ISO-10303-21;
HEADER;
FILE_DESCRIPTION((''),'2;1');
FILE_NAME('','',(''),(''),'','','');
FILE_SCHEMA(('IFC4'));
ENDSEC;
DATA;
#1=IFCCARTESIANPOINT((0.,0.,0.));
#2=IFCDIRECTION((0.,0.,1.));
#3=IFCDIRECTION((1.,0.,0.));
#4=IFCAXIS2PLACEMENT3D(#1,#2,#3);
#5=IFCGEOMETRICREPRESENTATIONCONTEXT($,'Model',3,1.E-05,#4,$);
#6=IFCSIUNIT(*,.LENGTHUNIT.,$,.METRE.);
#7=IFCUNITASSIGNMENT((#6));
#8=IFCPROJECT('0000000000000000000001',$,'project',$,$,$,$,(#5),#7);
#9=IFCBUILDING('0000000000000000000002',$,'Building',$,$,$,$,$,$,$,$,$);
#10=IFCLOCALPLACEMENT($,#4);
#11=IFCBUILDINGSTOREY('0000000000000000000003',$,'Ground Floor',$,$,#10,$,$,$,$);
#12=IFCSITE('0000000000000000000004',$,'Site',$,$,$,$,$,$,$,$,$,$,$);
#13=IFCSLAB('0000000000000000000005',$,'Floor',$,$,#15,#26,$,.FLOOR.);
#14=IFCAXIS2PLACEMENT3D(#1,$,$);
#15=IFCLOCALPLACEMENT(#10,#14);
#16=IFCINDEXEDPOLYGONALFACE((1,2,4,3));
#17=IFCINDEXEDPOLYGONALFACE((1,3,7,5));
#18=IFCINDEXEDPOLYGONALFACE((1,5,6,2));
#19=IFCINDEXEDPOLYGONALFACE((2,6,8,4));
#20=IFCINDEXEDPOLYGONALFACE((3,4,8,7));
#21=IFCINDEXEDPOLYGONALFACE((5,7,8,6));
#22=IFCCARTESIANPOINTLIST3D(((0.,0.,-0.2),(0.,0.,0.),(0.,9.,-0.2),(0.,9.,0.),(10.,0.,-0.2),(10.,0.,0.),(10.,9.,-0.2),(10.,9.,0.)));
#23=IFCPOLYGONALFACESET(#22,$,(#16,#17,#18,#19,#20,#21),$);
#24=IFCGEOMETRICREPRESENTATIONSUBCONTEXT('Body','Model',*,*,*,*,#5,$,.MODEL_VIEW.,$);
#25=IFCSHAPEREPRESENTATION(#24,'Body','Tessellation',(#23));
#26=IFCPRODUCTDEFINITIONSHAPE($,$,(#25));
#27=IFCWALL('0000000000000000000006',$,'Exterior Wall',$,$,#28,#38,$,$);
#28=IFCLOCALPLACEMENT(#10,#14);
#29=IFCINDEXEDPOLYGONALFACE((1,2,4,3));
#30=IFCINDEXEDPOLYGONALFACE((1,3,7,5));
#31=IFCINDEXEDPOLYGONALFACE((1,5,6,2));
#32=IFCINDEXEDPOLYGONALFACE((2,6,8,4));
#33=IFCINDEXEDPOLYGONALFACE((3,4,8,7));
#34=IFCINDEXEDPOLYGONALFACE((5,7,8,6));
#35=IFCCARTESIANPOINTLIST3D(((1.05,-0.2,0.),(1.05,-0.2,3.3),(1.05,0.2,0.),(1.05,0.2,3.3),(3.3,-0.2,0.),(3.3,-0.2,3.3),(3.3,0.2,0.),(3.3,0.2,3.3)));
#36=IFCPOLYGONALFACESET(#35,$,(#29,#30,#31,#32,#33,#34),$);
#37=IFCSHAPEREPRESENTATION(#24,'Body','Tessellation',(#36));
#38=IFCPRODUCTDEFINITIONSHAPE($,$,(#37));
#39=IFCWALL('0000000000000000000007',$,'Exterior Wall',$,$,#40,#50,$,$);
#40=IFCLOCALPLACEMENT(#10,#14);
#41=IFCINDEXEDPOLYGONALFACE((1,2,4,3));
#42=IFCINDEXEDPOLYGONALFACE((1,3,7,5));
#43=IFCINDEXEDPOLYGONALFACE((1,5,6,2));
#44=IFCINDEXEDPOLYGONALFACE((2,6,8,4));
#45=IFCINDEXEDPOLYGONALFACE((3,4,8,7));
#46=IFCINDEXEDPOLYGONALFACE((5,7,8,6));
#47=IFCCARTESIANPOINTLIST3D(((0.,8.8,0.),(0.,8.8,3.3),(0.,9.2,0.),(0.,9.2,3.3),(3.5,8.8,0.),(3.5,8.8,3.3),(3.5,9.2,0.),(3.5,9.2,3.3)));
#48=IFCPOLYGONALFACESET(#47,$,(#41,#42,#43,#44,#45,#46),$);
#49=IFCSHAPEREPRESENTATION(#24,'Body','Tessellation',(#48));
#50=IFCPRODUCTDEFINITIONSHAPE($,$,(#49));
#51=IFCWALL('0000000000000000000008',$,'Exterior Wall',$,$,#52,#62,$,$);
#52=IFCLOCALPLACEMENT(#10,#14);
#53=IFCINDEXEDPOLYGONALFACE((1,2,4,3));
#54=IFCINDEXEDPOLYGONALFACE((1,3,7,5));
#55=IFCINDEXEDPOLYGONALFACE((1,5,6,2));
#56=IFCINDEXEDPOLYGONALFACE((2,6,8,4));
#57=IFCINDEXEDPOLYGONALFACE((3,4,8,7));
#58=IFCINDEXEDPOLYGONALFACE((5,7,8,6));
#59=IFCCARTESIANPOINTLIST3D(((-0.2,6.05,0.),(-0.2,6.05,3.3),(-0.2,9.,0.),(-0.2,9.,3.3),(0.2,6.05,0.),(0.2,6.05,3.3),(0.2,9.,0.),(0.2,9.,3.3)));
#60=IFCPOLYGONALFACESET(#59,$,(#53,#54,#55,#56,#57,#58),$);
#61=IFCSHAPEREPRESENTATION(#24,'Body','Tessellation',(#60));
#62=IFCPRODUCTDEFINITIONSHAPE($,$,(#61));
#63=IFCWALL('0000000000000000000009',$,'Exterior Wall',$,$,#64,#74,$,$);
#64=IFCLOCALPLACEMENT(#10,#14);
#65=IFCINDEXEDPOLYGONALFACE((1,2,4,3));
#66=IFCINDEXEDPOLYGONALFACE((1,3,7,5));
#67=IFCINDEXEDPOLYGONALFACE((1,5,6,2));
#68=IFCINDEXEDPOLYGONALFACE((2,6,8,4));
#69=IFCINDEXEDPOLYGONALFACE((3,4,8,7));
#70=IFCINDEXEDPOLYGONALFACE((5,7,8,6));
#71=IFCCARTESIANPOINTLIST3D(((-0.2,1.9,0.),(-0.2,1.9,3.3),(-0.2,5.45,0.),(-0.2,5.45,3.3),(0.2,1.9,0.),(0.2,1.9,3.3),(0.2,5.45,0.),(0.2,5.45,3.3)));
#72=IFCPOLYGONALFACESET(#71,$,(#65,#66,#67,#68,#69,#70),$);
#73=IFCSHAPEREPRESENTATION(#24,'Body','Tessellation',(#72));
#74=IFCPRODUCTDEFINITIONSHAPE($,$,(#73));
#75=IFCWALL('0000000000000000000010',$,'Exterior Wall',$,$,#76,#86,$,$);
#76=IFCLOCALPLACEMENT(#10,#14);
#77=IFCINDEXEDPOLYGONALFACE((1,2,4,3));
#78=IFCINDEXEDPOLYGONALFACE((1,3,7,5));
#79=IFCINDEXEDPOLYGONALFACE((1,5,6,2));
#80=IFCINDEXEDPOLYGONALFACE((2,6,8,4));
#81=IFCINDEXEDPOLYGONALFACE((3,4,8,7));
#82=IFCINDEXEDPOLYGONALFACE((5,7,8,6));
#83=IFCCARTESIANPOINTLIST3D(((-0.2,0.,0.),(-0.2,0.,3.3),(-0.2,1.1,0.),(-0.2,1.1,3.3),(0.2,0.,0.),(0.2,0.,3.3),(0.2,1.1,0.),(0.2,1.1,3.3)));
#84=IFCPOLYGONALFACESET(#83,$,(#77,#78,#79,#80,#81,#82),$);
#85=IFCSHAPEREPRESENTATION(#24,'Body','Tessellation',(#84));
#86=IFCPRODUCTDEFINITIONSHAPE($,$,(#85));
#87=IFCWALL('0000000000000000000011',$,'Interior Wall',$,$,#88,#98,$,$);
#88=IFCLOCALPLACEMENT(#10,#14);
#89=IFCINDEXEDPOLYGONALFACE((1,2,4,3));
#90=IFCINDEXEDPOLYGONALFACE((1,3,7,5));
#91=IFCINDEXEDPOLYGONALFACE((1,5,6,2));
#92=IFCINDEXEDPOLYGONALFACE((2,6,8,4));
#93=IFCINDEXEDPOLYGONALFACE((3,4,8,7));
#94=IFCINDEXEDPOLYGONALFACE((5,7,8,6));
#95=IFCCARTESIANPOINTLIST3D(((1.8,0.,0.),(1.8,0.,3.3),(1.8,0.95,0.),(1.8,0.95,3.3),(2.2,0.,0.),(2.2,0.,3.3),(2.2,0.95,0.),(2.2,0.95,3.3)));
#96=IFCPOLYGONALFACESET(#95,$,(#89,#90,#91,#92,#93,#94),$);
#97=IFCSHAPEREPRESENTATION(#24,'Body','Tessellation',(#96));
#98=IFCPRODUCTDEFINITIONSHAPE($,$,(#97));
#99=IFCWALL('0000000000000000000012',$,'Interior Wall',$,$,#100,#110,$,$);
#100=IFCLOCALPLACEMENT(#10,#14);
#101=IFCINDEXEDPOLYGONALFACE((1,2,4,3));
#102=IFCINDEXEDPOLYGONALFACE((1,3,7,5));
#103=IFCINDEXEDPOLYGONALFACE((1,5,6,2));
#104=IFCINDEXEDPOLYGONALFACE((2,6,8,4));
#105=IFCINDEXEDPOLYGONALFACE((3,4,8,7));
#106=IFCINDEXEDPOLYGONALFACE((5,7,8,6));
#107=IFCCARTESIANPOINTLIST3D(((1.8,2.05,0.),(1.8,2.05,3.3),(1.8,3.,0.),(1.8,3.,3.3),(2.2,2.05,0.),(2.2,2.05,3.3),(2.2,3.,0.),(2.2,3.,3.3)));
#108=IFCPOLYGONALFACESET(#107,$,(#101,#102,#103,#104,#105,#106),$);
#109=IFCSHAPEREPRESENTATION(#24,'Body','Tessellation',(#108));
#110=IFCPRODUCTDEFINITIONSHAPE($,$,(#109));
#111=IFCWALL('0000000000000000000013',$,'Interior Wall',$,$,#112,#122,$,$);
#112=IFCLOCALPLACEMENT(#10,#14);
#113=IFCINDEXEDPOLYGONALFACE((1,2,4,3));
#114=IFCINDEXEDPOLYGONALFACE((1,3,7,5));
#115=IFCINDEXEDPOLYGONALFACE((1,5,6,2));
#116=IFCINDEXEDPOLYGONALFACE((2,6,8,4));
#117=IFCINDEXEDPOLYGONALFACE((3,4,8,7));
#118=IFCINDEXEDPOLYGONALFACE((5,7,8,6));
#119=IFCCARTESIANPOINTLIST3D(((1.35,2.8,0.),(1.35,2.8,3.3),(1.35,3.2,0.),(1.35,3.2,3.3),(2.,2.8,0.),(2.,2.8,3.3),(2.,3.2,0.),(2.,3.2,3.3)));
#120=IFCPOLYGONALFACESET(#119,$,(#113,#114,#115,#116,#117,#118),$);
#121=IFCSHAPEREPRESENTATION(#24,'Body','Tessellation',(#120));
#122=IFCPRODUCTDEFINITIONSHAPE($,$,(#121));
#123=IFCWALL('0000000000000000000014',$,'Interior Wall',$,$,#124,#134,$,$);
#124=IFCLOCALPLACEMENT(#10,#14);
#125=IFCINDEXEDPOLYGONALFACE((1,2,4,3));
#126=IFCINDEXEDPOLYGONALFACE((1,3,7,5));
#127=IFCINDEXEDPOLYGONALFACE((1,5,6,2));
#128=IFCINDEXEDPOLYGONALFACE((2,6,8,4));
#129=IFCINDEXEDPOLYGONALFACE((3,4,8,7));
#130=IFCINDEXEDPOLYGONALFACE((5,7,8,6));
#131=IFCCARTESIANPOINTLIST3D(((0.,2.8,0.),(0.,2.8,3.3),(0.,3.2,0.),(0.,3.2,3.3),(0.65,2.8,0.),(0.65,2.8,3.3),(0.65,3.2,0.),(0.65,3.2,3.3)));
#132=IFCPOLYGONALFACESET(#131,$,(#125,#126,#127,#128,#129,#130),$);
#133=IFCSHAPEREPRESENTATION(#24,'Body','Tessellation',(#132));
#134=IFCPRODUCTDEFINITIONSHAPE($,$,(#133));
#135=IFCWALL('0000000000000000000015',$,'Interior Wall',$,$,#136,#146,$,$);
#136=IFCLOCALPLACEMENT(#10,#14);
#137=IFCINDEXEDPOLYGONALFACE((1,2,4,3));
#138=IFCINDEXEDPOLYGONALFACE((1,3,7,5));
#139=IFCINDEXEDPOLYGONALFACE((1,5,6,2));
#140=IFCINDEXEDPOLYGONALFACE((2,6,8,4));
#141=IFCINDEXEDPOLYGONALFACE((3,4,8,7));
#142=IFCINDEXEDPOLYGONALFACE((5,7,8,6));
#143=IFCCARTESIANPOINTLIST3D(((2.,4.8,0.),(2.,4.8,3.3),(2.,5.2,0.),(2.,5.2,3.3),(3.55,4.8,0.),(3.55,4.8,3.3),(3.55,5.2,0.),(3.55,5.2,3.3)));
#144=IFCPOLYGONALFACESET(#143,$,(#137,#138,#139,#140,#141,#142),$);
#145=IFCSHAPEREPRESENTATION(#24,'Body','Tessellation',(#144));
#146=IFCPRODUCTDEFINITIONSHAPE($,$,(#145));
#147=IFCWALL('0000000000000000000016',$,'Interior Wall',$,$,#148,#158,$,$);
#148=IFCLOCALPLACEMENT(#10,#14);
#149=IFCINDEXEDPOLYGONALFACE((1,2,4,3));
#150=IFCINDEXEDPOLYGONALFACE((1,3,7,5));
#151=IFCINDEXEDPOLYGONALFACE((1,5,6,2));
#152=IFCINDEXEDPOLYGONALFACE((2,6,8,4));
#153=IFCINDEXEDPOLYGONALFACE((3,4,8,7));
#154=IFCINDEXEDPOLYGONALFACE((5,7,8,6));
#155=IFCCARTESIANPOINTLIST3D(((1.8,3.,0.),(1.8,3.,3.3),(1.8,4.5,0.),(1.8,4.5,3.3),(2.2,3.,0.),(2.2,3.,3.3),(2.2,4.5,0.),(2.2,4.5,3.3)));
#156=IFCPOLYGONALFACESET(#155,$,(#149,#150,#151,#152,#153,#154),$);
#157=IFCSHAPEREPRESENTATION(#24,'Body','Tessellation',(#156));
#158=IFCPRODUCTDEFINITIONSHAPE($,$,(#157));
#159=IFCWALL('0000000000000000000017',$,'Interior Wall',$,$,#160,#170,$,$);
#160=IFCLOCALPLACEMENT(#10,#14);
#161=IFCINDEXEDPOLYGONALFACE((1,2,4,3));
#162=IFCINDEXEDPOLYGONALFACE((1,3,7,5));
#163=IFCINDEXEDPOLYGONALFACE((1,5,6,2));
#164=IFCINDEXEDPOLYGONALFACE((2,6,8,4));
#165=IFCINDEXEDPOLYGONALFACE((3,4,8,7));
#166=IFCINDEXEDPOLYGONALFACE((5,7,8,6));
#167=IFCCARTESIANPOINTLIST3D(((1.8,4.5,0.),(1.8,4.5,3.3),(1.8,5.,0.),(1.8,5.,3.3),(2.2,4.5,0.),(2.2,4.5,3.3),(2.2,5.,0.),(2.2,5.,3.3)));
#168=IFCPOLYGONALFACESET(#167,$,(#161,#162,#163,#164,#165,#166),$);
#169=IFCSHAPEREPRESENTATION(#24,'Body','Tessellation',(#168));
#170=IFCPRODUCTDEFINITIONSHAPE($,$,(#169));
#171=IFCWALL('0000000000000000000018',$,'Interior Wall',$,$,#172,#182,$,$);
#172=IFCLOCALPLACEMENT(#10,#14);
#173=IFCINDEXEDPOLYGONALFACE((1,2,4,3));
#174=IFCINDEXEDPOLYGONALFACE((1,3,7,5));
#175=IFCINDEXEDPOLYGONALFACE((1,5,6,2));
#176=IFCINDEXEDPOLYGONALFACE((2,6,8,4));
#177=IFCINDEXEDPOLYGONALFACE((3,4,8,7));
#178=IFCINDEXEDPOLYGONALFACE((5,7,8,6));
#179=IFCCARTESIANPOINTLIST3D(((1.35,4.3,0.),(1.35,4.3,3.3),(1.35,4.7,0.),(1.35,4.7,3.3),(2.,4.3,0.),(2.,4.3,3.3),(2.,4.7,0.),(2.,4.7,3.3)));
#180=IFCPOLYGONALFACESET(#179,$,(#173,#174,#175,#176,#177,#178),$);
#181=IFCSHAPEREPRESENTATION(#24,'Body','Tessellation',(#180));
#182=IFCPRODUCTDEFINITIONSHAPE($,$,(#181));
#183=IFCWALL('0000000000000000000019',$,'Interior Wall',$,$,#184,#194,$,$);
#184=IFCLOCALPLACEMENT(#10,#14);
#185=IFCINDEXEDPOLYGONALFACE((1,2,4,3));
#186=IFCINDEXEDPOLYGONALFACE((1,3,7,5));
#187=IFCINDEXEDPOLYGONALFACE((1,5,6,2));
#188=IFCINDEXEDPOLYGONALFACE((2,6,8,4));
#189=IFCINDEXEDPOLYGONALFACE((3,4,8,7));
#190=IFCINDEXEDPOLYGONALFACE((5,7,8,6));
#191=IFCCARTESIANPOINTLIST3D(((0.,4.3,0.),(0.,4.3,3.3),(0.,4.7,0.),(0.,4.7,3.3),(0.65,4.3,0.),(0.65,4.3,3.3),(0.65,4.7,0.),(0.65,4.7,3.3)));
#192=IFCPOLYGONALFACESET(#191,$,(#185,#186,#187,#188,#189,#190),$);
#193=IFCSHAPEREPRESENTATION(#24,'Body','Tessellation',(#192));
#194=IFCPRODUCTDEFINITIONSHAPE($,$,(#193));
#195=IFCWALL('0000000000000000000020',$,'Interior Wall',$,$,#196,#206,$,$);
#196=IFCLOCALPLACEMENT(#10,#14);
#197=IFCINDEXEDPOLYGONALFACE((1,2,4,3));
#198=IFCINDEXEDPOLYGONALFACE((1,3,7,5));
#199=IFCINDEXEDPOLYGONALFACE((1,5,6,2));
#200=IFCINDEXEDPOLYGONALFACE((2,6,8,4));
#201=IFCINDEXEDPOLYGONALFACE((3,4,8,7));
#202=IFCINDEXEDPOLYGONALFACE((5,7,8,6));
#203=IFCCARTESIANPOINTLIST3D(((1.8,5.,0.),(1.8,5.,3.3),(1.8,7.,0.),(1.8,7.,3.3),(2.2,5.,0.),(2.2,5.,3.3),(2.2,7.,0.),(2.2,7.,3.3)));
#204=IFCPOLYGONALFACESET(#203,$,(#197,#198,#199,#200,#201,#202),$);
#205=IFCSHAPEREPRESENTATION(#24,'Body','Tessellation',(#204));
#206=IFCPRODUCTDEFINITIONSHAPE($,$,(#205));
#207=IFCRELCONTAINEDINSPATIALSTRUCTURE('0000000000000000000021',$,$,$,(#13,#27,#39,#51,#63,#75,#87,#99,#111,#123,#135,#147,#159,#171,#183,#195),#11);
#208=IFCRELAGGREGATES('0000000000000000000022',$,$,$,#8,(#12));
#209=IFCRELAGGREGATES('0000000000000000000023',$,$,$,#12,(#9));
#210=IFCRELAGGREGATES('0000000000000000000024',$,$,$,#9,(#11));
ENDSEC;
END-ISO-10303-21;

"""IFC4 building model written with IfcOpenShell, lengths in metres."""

from ifc_helpers import new_model, si_unit, frame, origin_with_axes, place, context, subcontext, project, spatial, indexed_curve, outline, extrude, element, save


model = new_model("IFC4")

# Units and contexts
model_context = context("Model", 3, precision=1e-05, world=origin_with_axes())
body_context = subcontext(model_context, "Body", "Model", "MODEL_VIEW")
ifc_project = project(units=[si_unit("LENGTHUNIT", "METRE")], contexts=[model_context])

# Site, building, storey
site = spatial("IfcSite", under=ifc_project, Name="Site")
building = spatial("IfcBuilding", under=site, Name="Building")
storey_placement = place(None, origin_with_axes())
storey = spatial("IfcBuildingStorey", under=building, at=storey_placement, Name="Ground Floor")

# Slab
slab_placement = place(storey_placement, frame((0.0, 0.0, -0.2), z_axis=(0.0, 0.0, 1.0), x_axis=(1.0, 0.0, 0.0)))
element("IfcSlab", 1, at=slab_placement, inside=storey, Name="Floor", PredefinedType="FLOOR", context=body_context, shape_type="SweptSolid", body=[
    extrude(outline(indexed_curve([(0.0, 0.0), (10.0, 0.0), (10.0, 9.0), (0.0, 9.0)])), None, (0.0, 0.0, 1.0), 0.2),
])

# Walls
wall_1_placement = place(storey_placement, frame((1.05, 0.0, 0.0), z_axis=(0.0, 0.0, 1.0), x_axis=(1.0, 0.0, 0.0)))
element("IfcWall", 2, at=wall_1_placement, inside=storey, Name="Exterior Wall", context=body_context, shape_type="SweptSolid", body=[
    extrude(outline(indexed_curve([(0.0, 0.0), (0.0, 0.4), (2.25, 0.4), (2.25, 0.0), (0.0, 0.0)], self_intersect=False)), frame((0.0, -0.2, 0.0), z_axis=(0.0, 0.0, 1.0), x_axis=(1.0, 0.0, 0.0)), (0.0, 0.0, 1.0), 3.3),
])
wall_2_placement = place(storey_placement, frame((3.5, 9.0, 0.0), z_axis=(0.0, 0.0, 1.0), x_axis=(-1.0, 0.0, 0.0)))
element("IfcWall", 3, at=wall_2_placement, inside=storey, Name="Exterior Wall", context=body_context, shape_type="SweptSolid", body=[
    extrude(outline(indexed_curve([(0.0, 0.0), (0.0, 0.4), (3.5, 0.4), (3.5, 0.0), (0.0, 0.0)], self_intersect=False)), frame((0.0, -0.2, 0.0), z_axis=(0.0, 0.0, 1.0), x_axis=(1.0, 0.0, 0.0)), (0.0, 0.0, 1.0), 3.3),
])
wall_3_placement = place(storey_placement, frame((0.0, 9.0, 0.0), z_axis=(0.0, 0.0, 1.0), x_axis=(0.0, -1.0, 0.0)))
element("IfcWall", 4, at=wall_3_placement, inside=storey, Name="Exterior Wall", context=body_context, shape_type="SweptSolid", body=[
    extrude(outline(indexed_curve([(0.0, 0.0), (0.0, 0.4), (2.95, 0.4), (2.95, 0.0), (0.0, 0.0)], self_intersect=False)), frame((0.0, -0.2, 0.0), z_axis=(0.0, 0.0, 1.0), x_axis=(1.0, 0.0, 0.0)), (0.0, 0.0, 1.0), 3.3),
])
wall_4_placement = place(storey_placement, frame((0.0, 5.45, 0.0), z_axis=(0.0, 0.0, 1.0), x_axis=(0.0, -1.0, 0.0)))
element("IfcWall", 5, at=wall_4_placement, inside=storey, Name="Exterior Wall", context=body_context, shape_type="SweptSolid", body=[
    extrude(outline(indexed_curve([(0.0, 0.0), (0.0, 0.4), (3.55, 0.4), (3.55, 0.0), (0.0, 0.0)], self_intersect=False)), frame((0.0, -0.2, 0.0), z_axis=(0.0, 0.0, 1.0), x_axis=(1.0, 0.0, 0.0)), (0.0, 0.0, 1.0), 3.3),
])
wall_5_placement = place(storey_placement, frame((0.0, 1.1, 0.0), z_axis=(0.0, 0.0, 1.0), x_axis=(0.0, -1.0, 0.0)))
element("IfcWall", 6, at=wall_5_placement, inside=storey, Name="Exterior Wall", context=body_context, shape_type="SweptSolid", body=[
    extrude(outline(indexed_curve([(0.0, 0.0), (0.0, 0.4), (1.1, 0.4), (1.1, 0.0), (0.0, 0.0)], self_intersect=False)), frame((0.0, -0.2, 0.0), z_axis=(0.0, 0.0, 1.0), x_axis=(1.0, 0.0, 0.0)), (0.0, 0.0, 1.0), 3.3),
])
wall_6_placement = place(storey_placement, frame((2.0, 0.0, 0.0), z_axis=(0.0, 0.0, 1.0), x_axis=(0.0, 1.0, 0.0)))
element("IfcWall", 7, at=wall_6_placement, inside=storey, Name="Interior Wall", context=body_context, shape_type="SweptSolid", body=[
    extrude(outline(indexed_curve([(0.0, 0.0), (0.0, 0.4), (0.95, 0.4), (0.95, 0.0), (0.0, 0.0)], self_intersect=False)), frame((0.0, -0.2, 0.0), z_axis=(0.0, 0.0, 1.0), x_axis=(1.0, 0.0, 0.0)), (0.0, 0.0, 1.0), 3.3),
])
wall_7_placement = place(storey_placement, frame((2.0, 2.05, 0.0), z_axis=(0.0, 0.0, 1.0), x_axis=(0.0, 1.0, 0.0)))
element("IfcWall", 8, at=wall_7_placement, inside=storey, Name="Interior Wall", context=body_context, shape_type="SweptSolid", body=[
    extrude(outline(indexed_curve([(0.0, 0.0), (0.0, 0.4), (0.95, 0.4), (0.95, 0.0), (0.0, 0.0)], self_intersect=False)), frame((0.0, -0.2, 0.0), z_axis=(0.0, 0.0, 1.0), x_axis=(1.0, 0.0, 0.0)), (0.0, 0.0, 1.0), 3.3),
])
for number, where, z_axis, x_axis, name in (
    (9, (2.0, 3.0, 0.0), (0.0, 0.0, 1.0), (-1.0, 0.0, 0.0), "Interior Wall"),
    (10, (0.65, 3.0, 0.0), (0.0, 0.0, 1.0), (-1.0, 0.0, 0.0), "Interior Wall"),
):
    element("IfcWall", number, at=place(storey_placement, frame(where, z_axis=z_axis, x_axis=x_axis)), inside=storey, Name=name, context=body_context, shape_type="SweptSolid", body=[
        extrude(outline(indexed_curve([(0.0, 0.0), (0.0, 0.4), (0.65, 0.4), (0.65, 0.0), (0.0, 0.0)], self_intersect=False)), frame((0.0, -0.2, 0.0), z_axis=(0.0, 0.0, 1.0), x_axis=(1.0, 0.0, 0.0)), (0.0, 0.0, 1.0), 3.3),
    ])
wall_8_placement = place(storey_placement, frame((3.55, 5.0, 0.0), z_axis=(0.0, 0.0, 1.0), x_axis=(-1.0, 0.0, 0.0)))
element("IfcWall", 11, at=wall_8_placement, inside=storey, Name="Interior Wall", context=body_context, shape_type="SweptSolid", body=[
    extrude(outline(indexed_curve([(0.0, 0.0), (0.0, 0.4), (1.55, 0.4), (1.55, 0.0), (0.0, 0.0)], self_intersect=False)), frame((0.0, -0.2, 0.0), z_axis=(0.0, 0.0, 1.0), x_axis=(1.0, 0.0, 0.0)), (0.0, 0.0, 1.0), 3.3),
])
wall_9_placement = place(storey_placement, frame((2.0, 4.5, 0.0), z_axis=(0.0, 0.0, 1.0), x_axis=(0.0, -1.0, 0.0)))
element("IfcWall", 12, at=wall_9_placement, inside=storey, Name="Interior Wall", context=body_context, shape_type="SweptSolid", body=[
    extrude(outline(indexed_curve([(0.0, 0.0), (0.0, 0.4), (1.5, 0.4), (1.5, 0.0), (0.0, 0.0)], self_intersect=False)), frame((0.0, -0.2, 0.0), z_axis=(0.0, 0.0, 1.0), x_axis=(1.0, 0.0, 0.0)), (0.0, 0.0, 1.0), 3.3),
])
wall_10_placement = place(storey_placement, frame((2.0, 5.0, 0.0), z_axis=(0.0, 0.0, 1.0), x_axis=(0.0, -1.0, 0.0)))
element("IfcWall", 13, at=wall_10_placement, inside=storey, Name="Interior Wall", context=body_context, shape_type="SweptSolid", body=[
    extrude(outline(indexed_curve([(0.0, 0.0), (0.0, 0.4), (0.5, 0.4), (0.5, 0.0), (0.0, 0.0)], self_intersect=False)), frame((0.0, -0.2, 0.0), z_axis=(0.0, 0.0, 1.0), x_axis=(1.0, 0.0, 0.0)), (0.0, 0.0, 1.0), 3.3),
])
for number, where, z_axis, x_axis, name in (
    (14, (2.0, 4.5, 0.0), (0.0, 0.0, 1.0), (-1.0, 0.0, 0.0), "Interior Wall"),
    (15, (0.65, 4.5, 0.0), (0.0, 0.0, 1.0), (-1.0, 0.0, 0.0), "Interior Wall"),
):
    element("IfcWall", number, at=place(storey_placement, frame(where, z_axis=z_axis, x_axis=x_axis)), inside=storey, Name=name, context=body_context, shape_type="SweptSolid", body=[
        extrude(outline(indexed_curve([(0.0, 0.0), (0.0, 0.4), (0.65, 0.4), (0.65, 0.0), (0.0, 0.0)], self_intersect=False)), frame((0.0, -0.2, 0.0), z_axis=(0.0, 0.0, 1.0), x_axis=(1.0, 0.0, 0.0)), (0.0, 0.0, 1.0), 3.3),
    ])
wall_11_placement = place(storey_placement, frame((2.0, 5.0, 0.0), z_axis=(0.0, 0.0, 1.0), x_axis=(0.0, 1.0, 0.0)))
element("IfcWall", 16, at=wall_11_placement, inside=storey, Name="Interior Wall", context=body_context, shape_type="SweptSolid", body=[
    extrude(outline(indexed_curve([(0.0, 0.0), (0.0, 0.4), (2.0, 0.4), (2.0, 0.0), (0.0, 0.0)], self_intersect=False)), frame((0.0, -0.2, 0.0), z_axis=(0.0, 0.0, 1.0), x_axis=(1.0, 0.0, 0.0)), (0.0, 0.0, 1.0), 3.3),
])

save(model, "model.ifc")
